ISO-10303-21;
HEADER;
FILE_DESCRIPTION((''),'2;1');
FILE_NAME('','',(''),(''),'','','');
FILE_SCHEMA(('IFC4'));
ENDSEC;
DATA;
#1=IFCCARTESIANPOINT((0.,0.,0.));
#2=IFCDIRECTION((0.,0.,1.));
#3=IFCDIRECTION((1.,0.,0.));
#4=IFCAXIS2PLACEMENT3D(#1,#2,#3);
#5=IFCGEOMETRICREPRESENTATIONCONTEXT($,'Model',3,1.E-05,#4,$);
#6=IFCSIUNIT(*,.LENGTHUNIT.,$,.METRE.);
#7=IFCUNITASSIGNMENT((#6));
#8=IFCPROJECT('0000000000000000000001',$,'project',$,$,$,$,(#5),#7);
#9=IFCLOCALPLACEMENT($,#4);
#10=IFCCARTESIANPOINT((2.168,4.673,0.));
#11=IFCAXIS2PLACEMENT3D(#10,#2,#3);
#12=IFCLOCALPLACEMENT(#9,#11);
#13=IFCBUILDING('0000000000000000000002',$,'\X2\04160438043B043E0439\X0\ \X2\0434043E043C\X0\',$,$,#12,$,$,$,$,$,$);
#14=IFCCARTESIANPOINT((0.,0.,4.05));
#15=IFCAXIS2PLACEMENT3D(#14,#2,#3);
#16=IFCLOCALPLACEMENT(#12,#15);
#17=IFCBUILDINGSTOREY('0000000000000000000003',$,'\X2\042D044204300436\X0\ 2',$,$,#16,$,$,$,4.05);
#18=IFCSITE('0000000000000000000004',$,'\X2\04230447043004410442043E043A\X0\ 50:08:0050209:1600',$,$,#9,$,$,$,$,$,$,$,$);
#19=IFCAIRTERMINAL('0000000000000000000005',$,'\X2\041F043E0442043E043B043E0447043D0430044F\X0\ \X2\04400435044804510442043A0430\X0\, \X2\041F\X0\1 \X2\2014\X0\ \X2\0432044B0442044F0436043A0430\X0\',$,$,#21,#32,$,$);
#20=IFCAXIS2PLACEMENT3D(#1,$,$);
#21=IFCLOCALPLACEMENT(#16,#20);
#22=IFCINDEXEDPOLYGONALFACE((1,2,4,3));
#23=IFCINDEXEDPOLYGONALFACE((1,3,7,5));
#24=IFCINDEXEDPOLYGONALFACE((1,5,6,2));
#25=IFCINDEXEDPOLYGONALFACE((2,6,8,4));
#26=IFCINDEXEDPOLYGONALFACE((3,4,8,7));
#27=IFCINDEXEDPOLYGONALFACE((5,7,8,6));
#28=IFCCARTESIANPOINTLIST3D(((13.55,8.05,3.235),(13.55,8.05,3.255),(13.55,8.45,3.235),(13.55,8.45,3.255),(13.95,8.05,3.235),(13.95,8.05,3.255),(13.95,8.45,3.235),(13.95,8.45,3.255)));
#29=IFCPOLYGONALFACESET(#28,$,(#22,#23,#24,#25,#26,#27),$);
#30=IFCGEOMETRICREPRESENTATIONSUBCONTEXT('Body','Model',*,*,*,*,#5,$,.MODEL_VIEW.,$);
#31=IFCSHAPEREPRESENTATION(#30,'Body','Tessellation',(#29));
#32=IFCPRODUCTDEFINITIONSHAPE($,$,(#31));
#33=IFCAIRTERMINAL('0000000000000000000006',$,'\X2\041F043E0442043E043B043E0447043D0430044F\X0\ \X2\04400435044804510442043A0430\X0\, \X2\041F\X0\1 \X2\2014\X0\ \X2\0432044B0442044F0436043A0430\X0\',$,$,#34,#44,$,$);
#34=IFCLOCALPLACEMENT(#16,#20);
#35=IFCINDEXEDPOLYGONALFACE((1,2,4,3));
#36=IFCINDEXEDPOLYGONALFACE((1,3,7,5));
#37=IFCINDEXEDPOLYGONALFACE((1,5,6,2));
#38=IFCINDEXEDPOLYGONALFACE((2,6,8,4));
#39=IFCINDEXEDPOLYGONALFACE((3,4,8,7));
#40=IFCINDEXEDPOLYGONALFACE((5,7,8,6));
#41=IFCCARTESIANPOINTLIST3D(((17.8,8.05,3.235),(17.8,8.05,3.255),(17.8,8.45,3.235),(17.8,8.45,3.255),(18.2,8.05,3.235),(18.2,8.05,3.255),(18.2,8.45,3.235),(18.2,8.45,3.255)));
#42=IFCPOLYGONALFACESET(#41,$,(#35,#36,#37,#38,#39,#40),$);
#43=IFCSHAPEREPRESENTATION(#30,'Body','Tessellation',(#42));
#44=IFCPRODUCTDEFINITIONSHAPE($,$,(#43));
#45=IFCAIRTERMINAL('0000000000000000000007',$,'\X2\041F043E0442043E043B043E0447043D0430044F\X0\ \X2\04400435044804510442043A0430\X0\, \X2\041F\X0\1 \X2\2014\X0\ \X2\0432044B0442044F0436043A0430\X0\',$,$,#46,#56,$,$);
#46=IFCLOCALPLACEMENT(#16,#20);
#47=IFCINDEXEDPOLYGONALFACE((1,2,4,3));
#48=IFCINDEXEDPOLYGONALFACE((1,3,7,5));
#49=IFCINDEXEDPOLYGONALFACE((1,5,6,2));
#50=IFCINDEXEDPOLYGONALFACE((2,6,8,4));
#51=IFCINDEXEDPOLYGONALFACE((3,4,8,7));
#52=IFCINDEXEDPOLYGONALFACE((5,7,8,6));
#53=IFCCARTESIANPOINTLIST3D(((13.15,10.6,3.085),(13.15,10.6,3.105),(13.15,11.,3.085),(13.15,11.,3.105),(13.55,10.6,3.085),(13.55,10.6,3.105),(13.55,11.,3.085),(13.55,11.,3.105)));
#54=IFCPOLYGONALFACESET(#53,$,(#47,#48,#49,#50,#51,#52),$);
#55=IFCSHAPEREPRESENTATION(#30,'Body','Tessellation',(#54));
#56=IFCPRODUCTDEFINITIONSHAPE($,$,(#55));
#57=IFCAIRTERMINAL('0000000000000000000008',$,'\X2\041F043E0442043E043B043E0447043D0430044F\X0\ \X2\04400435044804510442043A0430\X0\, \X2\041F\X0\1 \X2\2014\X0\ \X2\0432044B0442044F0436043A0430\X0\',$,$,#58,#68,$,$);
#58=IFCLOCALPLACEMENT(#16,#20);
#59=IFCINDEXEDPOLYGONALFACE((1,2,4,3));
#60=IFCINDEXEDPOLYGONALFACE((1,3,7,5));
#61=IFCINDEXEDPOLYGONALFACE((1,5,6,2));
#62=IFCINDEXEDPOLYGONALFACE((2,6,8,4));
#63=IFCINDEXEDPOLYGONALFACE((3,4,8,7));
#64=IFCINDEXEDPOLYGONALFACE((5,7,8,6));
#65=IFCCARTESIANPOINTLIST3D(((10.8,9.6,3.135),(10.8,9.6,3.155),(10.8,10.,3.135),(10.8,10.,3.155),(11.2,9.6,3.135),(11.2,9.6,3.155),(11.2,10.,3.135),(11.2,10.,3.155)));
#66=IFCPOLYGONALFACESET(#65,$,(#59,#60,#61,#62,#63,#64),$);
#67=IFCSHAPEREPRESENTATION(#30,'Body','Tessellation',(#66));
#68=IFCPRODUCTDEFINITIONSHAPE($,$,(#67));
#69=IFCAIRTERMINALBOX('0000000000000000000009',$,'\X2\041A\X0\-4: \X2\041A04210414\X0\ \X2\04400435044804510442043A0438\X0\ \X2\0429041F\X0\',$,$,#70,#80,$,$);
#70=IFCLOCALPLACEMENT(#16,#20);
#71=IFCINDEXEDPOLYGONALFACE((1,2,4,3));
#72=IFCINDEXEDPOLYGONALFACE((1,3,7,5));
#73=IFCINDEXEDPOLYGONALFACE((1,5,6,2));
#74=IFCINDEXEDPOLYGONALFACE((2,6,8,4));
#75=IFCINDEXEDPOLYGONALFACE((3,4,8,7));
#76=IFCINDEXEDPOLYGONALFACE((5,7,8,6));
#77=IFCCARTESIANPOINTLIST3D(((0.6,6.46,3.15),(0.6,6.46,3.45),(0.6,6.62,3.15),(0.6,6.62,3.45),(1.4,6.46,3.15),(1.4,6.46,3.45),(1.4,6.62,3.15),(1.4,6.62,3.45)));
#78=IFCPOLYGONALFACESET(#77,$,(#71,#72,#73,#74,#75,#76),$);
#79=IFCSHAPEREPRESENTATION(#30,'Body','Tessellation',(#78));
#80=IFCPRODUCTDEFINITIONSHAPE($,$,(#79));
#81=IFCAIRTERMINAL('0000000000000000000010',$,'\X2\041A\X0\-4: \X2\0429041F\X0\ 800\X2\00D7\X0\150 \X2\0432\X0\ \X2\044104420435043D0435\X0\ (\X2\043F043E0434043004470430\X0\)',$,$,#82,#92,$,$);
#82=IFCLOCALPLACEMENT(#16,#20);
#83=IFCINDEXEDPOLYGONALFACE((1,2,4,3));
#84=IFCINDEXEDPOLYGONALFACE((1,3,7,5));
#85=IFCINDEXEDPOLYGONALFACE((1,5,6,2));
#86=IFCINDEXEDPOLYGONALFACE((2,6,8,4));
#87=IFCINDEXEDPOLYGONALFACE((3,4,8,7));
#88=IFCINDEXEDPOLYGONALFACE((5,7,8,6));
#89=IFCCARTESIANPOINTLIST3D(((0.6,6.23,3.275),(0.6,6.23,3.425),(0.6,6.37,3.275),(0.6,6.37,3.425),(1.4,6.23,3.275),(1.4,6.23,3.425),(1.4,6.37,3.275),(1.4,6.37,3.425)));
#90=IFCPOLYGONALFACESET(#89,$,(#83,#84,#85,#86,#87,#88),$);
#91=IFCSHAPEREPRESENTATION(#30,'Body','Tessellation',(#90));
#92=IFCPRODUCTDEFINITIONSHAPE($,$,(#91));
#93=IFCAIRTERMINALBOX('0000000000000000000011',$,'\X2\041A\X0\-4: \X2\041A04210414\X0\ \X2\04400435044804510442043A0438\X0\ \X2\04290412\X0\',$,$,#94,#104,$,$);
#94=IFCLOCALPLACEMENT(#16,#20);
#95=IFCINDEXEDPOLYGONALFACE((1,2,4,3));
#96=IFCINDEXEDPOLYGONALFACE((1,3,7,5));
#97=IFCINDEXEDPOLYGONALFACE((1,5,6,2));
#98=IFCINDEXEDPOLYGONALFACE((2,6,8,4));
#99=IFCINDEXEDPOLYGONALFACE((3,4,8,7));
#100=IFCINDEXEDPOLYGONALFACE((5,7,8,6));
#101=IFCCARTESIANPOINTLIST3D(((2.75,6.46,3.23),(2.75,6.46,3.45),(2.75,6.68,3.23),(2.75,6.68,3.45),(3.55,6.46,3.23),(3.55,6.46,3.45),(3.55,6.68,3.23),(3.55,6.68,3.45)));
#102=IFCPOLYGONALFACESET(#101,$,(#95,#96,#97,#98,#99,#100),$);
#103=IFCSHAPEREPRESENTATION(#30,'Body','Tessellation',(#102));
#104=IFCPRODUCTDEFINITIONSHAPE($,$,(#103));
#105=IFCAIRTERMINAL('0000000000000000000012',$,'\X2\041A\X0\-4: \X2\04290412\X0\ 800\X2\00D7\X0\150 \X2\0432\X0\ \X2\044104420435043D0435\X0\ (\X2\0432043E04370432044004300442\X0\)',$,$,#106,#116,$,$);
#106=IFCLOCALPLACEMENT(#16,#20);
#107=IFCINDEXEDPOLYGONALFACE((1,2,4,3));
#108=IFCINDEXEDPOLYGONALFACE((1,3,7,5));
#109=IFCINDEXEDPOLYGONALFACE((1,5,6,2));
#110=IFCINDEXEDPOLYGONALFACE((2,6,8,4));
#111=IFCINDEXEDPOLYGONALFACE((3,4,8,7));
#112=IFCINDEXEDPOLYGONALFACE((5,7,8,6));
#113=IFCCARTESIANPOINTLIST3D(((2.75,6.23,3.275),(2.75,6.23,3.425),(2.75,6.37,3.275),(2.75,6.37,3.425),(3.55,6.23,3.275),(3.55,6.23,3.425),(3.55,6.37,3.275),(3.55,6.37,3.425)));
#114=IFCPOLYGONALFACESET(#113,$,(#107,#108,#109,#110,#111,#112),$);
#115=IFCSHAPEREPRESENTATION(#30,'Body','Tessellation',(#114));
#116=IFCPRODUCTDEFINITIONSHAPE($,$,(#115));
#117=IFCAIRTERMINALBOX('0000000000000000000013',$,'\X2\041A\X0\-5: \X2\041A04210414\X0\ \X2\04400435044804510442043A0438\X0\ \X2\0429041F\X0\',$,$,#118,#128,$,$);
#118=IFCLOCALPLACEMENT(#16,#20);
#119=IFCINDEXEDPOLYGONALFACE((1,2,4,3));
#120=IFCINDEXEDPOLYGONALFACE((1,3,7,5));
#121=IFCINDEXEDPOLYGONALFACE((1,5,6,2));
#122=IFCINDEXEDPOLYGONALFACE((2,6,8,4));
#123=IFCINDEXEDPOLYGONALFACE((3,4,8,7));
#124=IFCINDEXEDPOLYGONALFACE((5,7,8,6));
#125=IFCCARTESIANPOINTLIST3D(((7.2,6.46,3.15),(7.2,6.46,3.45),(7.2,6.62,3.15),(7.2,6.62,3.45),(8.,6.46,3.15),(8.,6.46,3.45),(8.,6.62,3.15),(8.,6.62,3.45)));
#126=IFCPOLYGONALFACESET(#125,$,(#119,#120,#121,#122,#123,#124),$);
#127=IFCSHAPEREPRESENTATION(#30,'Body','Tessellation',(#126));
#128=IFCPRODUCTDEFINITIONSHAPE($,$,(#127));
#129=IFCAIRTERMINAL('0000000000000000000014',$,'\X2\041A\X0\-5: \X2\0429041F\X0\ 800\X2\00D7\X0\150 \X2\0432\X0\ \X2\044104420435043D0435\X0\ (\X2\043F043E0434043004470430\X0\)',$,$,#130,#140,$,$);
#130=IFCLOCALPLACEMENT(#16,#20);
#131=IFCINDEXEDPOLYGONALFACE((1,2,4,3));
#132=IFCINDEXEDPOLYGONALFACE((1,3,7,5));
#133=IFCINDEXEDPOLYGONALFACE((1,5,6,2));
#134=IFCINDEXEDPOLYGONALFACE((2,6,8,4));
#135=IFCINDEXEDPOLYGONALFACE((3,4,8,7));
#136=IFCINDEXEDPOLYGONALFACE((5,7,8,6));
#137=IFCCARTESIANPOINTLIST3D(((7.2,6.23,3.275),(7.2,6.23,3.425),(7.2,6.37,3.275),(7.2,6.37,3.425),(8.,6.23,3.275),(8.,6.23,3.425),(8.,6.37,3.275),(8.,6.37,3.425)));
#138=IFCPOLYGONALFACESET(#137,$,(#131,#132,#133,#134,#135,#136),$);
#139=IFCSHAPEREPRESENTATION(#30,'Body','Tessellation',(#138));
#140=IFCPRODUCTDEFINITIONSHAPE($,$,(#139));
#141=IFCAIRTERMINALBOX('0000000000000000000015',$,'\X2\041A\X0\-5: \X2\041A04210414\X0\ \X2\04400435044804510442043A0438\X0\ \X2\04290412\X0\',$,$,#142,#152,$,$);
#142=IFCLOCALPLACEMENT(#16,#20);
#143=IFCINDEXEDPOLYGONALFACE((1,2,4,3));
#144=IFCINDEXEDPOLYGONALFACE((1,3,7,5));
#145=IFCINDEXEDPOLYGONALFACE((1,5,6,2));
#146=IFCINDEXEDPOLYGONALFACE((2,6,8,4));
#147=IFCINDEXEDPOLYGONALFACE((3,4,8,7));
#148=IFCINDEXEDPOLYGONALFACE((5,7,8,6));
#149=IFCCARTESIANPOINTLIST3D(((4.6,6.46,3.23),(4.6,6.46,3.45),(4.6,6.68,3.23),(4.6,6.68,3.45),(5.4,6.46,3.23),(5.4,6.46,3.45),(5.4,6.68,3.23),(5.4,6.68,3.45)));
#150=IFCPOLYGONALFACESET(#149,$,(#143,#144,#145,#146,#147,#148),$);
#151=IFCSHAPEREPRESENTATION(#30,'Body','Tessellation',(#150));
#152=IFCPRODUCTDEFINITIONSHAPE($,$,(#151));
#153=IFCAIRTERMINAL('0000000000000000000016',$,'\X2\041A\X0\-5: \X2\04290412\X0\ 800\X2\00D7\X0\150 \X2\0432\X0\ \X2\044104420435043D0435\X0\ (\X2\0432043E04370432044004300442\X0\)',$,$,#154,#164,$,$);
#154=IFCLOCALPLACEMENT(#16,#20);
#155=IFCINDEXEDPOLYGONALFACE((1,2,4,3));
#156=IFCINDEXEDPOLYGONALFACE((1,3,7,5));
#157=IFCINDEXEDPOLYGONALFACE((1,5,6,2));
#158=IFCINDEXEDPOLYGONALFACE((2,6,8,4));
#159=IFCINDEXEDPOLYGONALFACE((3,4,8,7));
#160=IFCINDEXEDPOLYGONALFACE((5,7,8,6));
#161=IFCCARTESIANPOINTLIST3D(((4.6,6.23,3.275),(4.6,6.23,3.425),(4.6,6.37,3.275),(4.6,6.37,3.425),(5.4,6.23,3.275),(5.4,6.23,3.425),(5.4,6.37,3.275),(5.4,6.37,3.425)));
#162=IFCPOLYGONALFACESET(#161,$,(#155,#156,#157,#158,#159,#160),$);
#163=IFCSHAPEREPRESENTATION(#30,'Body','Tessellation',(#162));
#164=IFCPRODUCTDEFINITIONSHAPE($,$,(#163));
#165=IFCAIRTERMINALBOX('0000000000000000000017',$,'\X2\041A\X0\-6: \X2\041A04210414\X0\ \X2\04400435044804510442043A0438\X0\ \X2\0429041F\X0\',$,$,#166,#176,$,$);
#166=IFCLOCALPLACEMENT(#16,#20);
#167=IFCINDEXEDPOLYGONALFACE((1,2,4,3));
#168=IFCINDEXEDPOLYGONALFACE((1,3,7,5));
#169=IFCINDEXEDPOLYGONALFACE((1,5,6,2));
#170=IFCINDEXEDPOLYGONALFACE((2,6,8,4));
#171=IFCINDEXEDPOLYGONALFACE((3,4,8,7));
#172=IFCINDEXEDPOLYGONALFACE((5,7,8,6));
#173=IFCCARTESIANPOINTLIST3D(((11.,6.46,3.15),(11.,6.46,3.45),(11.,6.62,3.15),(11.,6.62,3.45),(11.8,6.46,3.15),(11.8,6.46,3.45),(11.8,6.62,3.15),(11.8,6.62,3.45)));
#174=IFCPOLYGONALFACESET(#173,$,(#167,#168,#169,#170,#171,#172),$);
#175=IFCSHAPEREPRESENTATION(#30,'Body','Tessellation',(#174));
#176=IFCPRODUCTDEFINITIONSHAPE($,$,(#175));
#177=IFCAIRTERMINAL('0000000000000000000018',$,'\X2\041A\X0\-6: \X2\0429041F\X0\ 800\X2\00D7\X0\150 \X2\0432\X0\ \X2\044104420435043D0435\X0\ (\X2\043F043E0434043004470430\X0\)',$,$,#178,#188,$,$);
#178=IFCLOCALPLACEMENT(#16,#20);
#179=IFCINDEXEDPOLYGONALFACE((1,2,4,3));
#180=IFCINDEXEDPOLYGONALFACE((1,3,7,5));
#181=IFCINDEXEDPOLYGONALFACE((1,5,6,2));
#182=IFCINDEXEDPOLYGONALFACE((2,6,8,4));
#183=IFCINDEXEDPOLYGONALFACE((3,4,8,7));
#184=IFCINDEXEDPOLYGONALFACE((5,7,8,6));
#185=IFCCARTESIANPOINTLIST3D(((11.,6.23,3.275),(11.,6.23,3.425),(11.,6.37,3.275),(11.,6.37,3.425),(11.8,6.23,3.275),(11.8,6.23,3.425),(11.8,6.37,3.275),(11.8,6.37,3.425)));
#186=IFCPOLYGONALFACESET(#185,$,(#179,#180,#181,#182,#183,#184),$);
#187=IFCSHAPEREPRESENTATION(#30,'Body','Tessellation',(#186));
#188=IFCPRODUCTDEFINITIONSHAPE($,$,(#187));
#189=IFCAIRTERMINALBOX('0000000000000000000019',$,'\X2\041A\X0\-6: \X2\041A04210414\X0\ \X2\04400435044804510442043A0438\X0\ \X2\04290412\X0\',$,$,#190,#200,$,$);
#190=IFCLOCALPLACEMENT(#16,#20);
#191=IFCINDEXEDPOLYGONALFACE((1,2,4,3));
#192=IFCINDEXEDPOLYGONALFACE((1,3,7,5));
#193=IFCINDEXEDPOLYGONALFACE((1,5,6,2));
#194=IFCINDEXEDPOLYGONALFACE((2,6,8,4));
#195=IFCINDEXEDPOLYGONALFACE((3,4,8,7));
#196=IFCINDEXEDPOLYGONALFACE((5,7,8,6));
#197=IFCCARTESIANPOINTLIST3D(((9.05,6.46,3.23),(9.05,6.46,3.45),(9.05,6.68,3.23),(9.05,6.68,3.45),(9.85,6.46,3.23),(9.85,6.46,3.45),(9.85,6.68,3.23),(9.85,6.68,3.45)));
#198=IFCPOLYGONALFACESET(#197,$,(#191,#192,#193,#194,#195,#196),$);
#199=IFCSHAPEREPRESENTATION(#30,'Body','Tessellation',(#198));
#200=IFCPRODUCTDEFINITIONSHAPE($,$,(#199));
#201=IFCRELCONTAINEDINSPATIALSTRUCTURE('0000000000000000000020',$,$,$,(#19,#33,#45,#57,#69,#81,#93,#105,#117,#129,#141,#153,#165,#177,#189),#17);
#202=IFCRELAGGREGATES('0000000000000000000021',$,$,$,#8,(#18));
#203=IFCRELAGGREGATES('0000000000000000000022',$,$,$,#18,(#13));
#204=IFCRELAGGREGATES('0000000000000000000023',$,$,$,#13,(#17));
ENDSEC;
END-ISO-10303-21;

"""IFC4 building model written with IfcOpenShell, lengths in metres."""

from ifc_helpers import new_model, si_unit, frame, frame_2d, origin_with_axes, place, context, subcontext, project, spatial, rectangle, extrude, element, save


model = new_model("IFC4")

# Units and contexts
model_context = context("Model", 3, precision=1e-05, world=origin_with_axes())
body_context = subcontext(model_context, "Body", "Model", "MODEL_VIEW")
ifc_project = project(units=[si_unit("LENGTHUNIT", "METRE")], contexts=[model_context])

# Site, building, storey
site_placement = place(None, origin_with_axes())
site = spatial("IfcSite", under=ifc_project, at=site_placement, Name="Участок 50:08:0050209:1600")
building_placement = place(site_placement, frame((2.168, 4.673, 0.0), z_axis=(0.0, 0.0, 1.0), x_axis=(1.0, 0.0, 0.0)))
building = spatial("IfcBuilding", under=site, at=building_placement, Name="Жилой дом")
storey_placement = place(building_placement, frame((0.0, 0.0, 4.05), z_axis=(0.0, 0.0, 1.0), x_axis=(1.0, 0.0, 0.0)))
storey = spatial("IfcBuildingStorey", under=building, at=storey_placement, Name="Этаж 2", Elevation=4.05)

# Air terminals
air_terminal_1_placement = place(storey_placement, frame((0.0, 0.0, -4.05), z_axis=(0.0, 0.0, 1.0), x_axis=(1.0, 0.0, 0.0)))
element("IfcAirTerminal", 1, at=air_terminal_1_placement, inside=storey, Name="Потолочная решётка, П1 — вытяжка", context=body_context, shape_type="SweptSolid", body=[
    extrude(rectangle(XDim=0.4, YDim=0.4, at=frame_2d((0.2, 0.2))), frame((13.55, 8.05, 7.285), z_axis=(0.0, 0.0, 1.0), x_axis=(1.0, 0.0, 0.0)), (0.0, 0.0, 1.0), 0.02),
])
air_terminal_2_placement = place(storey_placement, frame((0.0, 0.0, -4.05), z_axis=(0.0, 0.0, 1.0), x_axis=(1.0, 0.0, 0.0)))
element("IfcAirTerminal", 2, at=air_terminal_2_placement, inside=storey, Name="Потолочная решётка, П1 — вытяжка", context=body_context, shape_type="SweptSolid", body=[
    extrude(rectangle(XDim=0.4, YDim=0.4, at=frame_2d((0.2, 0.2))), frame((17.8, 8.05, 7.285), z_axis=(0.0, 0.0, 1.0), x_axis=(1.0, 0.0, 0.0)), (0.0, 0.0, 1.0), 0.02),
])
air_terminal_3_placement = place(storey_placement, frame((0.0, 0.0, -4.05), z_axis=(0.0, 0.0, 1.0), x_axis=(1.0, 0.0, 0.0)))
element("IfcAirTerminal", 3, at=air_terminal_3_placement, inside=storey, Name="Потолочная решётка, П1 — вытяжка", context=body_context, shape_type="SweptSolid", body=[
    extrude(rectangle(XDim=0.4, YDim=0.4, at=frame_2d((0.2, 0.2))), frame((13.15, 10.6, 7.135), z_axis=(0.0, 0.0, 1.0), x_axis=(1.0, 0.0, 0.0)), (0.0, 0.0, 1.0), 0.02),
])
air_terminal_4_placement = place(storey_placement, frame((0.0, 0.0, -4.05), z_axis=(0.0, 0.0, 1.0), x_axis=(1.0, 0.0, 0.0)))
element("IfcAirTerminal", 4, at=air_terminal_4_placement, inside=storey, Name="Потолочная решётка, П1 — вытяжка", context=body_context, shape_type="SweptSolid", body=[
    extrude(rectangle(XDim=0.4, YDim=0.4, at=frame_2d((0.2, 0.2))), frame((10.8, 9.6, 7.185), z_axis=(0.0, 0.0, 1.0), x_axis=(1.0, 0.0, 0.0)), (0.0, 0.0, 1.0), 0.02),
])

# Air terminal box
air_terminal_box_1_placement = place(storey_placement, frame((0.0, 0.0, -4.05), z_axis=(0.0, 0.0, 1.0), x_axis=(1.0, 0.0, 0.0)))
element("IfcAirTerminalBox", 5, at=air_terminal_box_1_placement, inside=storey, Name="К-4: КСД решётки ЩП", context=body_context, shape_type="SweptSolid", body=[
    extrude(rectangle(XDim=0.8, YDim=0.16, at=frame_2d((0.4, 0.08))), frame((0.6, 6.46, 7.2), z_axis=(0.0, 0.0, 1.0), x_axis=(1.0, 0.0, 0.0)), (0.0, 0.0, 1.0), 0.3),
])

# Air terminal
air_terminal_5_placement = place(storey_placement, frame((0.0, 0.0, -4.05), z_axis=(0.0, 0.0, 1.0), x_axis=(1.0, 0.0, 0.0)))
element("IfcAirTerminal", 6, at=air_terminal_5_placement, inside=storey, Name="К-4: ЩП 800×150 в стене (подача)", context=body_context, shape_type="SweptSolid", body=[
    extrude(rectangle(XDim=0.8, YDim=0.14, at=frame_2d((0.4, 0.07))), frame((0.6, 6.23, 7.325), z_axis=(0.0, 0.0, 1.0), x_axis=(1.0, 0.0, 0.0)), (0.0, 0.0, 1.0), 0.15),
])

# Air terminal box
air_terminal_box_2_placement = place(storey_placement, frame((0.0, 0.0, -4.05), z_axis=(0.0, 0.0, 1.0), x_axis=(1.0, 0.0, 0.0)))
element("IfcAirTerminalBox", 7, at=air_terminal_box_2_placement, inside=storey, Name="К-4: КСД решётки ЩВ", context=body_context, shape_type="SweptSolid", body=[
    extrude(rectangle(XDim=0.8, YDim=0.22, at=frame_2d((0.4, 0.11))), frame((2.75, 6.46, 7.28), z_axis=(0.0, 0.0, 1.0), x_axis=(1.0, 0.0, 0.0)), (0.0, 0.0, 1.0), 0.22),
])

# Air terminal
air_terminal_6_placement = place(storey_placement, frame((0.0, 0.0, -4.05), z_axis=(0.0, 0.0, 1.0), x_axis=(1.0, 0.0, 0.0)))
element("IfcAirTerminal", 8, at=air_terminal_6_placement, inside=storey, Name="К-4: ЩВ 800×150 в стене (возврат)", context=body_context, shape_type="SweptSolid", body=[
    extrude(rectangle(XDim=0.8, YDim=0.14, at=frame_2d((0.4, 0.07))), frame((2.75, 6.23, 7.325), z_axis=(0.0, 0.0, 1.0), x_axis=(1.0, 0.0, 0.0)), (0.0, 0.0, 1.0), 0.15),
])

# Air terminal box
air_terminal_box_3_placement = place(storey_placement, frame((0.0, 0.0, -4.05), z_axis=(0.0, 0.0, 1.0), x_axis=(1.0, 0.0, 0.0)))
element("IfcAirTerminalBox", 9, at=air_terminal_box_3_placement, inside=storey, Name="К-5: КСД решётки ЩП", context=body_context, shape_type="SweptSolid", body=[
    extrude(rectangle(XDim=0.8, YDim=0.16, at=frame_2d((0.4, 0.08))), frame((7.2, 6.46, 7.2), z_axis=(0.0, 0.0, 1.0), x_axis=(1.0, 0.0, 0.0)), (0.0, 0.0, 1.0), 0.3),
])

# Air terminal
air_terminal_7_placement = place(storey_placement, frame((0.0, 0.0, -4.05), z_axis=(0.0, 0.0, 1.0), x_axis=(1.0, 0.0, 0.0)))
element("IfcAirTerminal", 10, at=air_terminal_7_placement, inside=storey, Name="К-5: ЩП 800×150 в стене (подача)", context=body_context, shape_type="SweptSolid", body=[
    extrude(rectangle(XDim=0.8, YDim=0.14, at=frame_2d((0.4, 0.07))), frame((7.2, 6.23, 7.325), z_axis=(0.0, 0.0, 1.0), x_axis=(1.0, 0.0, 0.0)), (0.0, 0.0, 1.0), 0.15),
])

# Air terminal box
air_terminal_box_4_placement = place(storey_placement, frame((0.0, 0.0, -4.05), z_axis=(0.0, 0.0, 1.0), x_axis=(1.0, 0.0, 0.0)))
element("IfcAirTerminalBox", 11, at=air_terminal_box_4_placement, inside=storey, Name="К-5: КСД решётки ЩВ", context=body_context, shape_type="SweptSolid", body=[
    extrude(rectangle(XDim=0.8, YDim=0.22, at=frame_2d((0.4, 0.11))), frame((4.6, 6.46, 7.28), z_axis=(0.0, 0.0, 1.0), x_axis=(1.0, 0.0, 0.0)), (0.0, 0.0, 1.0), 0.22),
])

# Air terminal
air_terminal_8_placement = place(storey_placement, frame((0.0, 0.0, -4.05), z_axis=(0.0, 0.0, 1.0), x_axis=(1.0, 0.0, 0.0)))
element("IfcAirTerminal", 12, at=air_terminal_8_placement, inside=storey, Name="К-5: ЩВ 800×150 в стене (возврат)", context=body_context, shape_type="SweptSolid", body=[
    extrude(rectangle(XDim=0.8, YDim=0.14, at=frame_2d((0.4, 0.07))), frame((4.6, 6.23, 7.325), z_axis=(0.0, 0.0, 1.0), x_axis=(1.0, 0.0, 0.0)), (0.0, 0.0, 1.0), 0.15),
])

# Air terminal box
air_terminal_box_5_placement = place(storey_placement, frame((0.0, 0.0, -4.05), z_axis=(0.0, 0.0, 1.0), x_axis=(1.0, 0.0, 0.0)))
element("IfcAirTerminalBox", 13, at=air_terminal_box_5_placement, inside=storey, Name="К-6: КСД решётки ЩП", context=body_context, shape_type="SweptSolid", body=[
    extrude(rectangle(XDim=0.8, YDim=0.16, at=frame_2d((0.4, 0.08))), frame((11.0, 6.46, 7.2), z_axis=(0.0, 0.0, 1.0), x_axis=(1.0, 0.0, 0.0)), (0.0, 0.0, 1.0), 0.3),
])

# Air terminal
air_terminal_9_placement = place(storey_placement, frame((0.0, 0.0, -4.05), z_axis=(0.0, 0.0, 1.0), x_axis=(1.0, 0.0, 0.0)))
element("IfcAirTerminal", 14, at=air_terminal_9_placement, inside=storey, Name="К-6: ЩП 800×150 в стене (подача)", context=body_context, shape_type="SweptSolid", body=[
    extrude(rectangle(XDim=0.8, YDim=0.14, at=frame_2d((0.4, 0.07))), frame((11.0, 6.23, 7.325), z_axis=(0.0, 0.0, 1.0), x_axis=(1.0, 0.0, 0.0)), (0.0, 0.0, 1.0), 0.15),
])

# Air terminal box
air_terminal_box_6_placement = place(storey_placement, frame((0.0, 0.0, -4.05), z_axis=(0.0, 0.0, 1.0), x_axis=(1.0, 0.0, 0.0)))
element("IfcAirTerminalBox", 15, at=air_terminal_box_6_placement, inside=storey, Name="К-6: КСД решётки ЩВ", context=body_context, shape_type="SweptSolid", body=[
    extrude(rectangle(XDim=0.8, YDim=0.22, at=frame_2d((0.4, 0.11))), frame((9.05, 6.46, 7.28), z_axis=(0.0, 0.0, 1.0), x_axis=(1.0, 0.0, 0.0)), (0.0, 0.0, 1.0), 0.22),
])

save(model, "model.ifc")
